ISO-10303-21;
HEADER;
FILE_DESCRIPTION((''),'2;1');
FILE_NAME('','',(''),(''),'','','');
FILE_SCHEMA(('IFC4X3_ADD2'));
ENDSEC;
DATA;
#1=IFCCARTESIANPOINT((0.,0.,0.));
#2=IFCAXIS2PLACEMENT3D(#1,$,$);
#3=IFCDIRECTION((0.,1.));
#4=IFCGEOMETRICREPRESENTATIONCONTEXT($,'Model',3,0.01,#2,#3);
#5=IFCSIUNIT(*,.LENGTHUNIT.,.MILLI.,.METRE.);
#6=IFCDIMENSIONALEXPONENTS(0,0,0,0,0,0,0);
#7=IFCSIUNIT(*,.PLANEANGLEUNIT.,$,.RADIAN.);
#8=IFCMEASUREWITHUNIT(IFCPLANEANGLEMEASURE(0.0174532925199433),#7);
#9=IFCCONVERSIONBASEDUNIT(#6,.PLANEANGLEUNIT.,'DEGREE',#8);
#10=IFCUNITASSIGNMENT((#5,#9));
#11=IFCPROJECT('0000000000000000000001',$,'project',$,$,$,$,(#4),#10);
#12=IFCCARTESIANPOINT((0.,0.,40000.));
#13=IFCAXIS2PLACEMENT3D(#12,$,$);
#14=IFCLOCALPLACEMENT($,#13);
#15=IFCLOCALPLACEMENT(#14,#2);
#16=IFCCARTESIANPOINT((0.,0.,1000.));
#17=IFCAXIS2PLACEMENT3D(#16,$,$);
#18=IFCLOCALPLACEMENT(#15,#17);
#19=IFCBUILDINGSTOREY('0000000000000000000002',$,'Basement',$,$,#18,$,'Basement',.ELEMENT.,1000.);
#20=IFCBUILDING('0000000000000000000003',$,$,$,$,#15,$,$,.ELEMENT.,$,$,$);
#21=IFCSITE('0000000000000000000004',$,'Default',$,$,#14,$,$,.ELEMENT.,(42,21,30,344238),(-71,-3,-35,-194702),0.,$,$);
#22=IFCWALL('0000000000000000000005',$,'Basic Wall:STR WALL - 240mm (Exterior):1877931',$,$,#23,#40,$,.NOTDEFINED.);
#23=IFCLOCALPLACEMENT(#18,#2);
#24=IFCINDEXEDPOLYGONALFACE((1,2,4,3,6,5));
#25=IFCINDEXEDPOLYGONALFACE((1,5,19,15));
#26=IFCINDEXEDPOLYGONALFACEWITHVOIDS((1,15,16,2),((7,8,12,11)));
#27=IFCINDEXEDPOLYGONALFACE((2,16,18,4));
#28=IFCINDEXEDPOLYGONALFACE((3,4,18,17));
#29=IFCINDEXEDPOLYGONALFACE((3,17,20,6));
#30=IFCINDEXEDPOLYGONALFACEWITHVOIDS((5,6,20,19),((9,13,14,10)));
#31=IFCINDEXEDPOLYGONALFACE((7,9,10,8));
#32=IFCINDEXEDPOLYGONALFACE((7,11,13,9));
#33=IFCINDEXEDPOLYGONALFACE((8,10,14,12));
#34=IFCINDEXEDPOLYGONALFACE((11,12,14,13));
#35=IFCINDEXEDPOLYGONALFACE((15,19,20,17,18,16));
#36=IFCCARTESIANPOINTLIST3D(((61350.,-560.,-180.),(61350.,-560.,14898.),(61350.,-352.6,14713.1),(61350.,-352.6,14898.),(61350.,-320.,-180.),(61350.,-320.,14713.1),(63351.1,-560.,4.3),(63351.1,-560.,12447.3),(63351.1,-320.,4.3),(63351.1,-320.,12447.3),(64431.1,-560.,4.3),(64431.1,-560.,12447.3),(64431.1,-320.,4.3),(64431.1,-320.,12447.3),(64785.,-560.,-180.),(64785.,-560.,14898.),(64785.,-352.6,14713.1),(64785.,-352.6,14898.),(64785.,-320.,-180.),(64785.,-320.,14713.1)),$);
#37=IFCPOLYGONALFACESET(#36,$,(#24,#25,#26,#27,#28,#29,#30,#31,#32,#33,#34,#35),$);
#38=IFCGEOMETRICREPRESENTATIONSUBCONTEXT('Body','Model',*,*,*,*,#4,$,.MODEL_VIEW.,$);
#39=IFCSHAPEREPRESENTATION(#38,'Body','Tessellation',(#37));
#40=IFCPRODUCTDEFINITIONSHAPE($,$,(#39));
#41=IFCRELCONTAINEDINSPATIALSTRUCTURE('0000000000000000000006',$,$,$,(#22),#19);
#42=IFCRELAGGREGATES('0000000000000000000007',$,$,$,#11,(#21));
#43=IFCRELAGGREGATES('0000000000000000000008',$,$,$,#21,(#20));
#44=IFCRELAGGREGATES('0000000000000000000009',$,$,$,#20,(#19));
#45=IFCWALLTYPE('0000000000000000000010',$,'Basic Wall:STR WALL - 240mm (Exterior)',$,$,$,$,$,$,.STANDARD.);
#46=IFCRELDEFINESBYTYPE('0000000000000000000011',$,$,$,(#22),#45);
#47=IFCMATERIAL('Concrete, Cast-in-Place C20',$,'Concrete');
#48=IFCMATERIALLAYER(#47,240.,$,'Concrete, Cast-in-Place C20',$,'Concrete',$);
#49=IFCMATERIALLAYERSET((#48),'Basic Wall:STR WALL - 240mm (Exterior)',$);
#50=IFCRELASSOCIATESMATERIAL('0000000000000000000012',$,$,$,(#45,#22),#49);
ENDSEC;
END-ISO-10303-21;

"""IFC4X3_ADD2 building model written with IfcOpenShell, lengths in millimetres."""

from ifc_helpers import new_model, entity, si_unit, converted_unit, direction, frame, frame_2d, origin, place, context, subcontext, project, spatial, polyline, rectangle, extrude, clip, bounded_halfspace, material, layer, layer_set, type_object, element, save


model = new_model("IFC4X3_ADD2")

# Units and contexts
model_context = context("Model", 3, precision=0.01, world=origin(), true_north=direction((0.0, 1.0)))
body_context = subcontext(model_context, "Body", "Model", "MODEL_VIEW")
ifc_project = project(units=[si_unit("LENGTHUNIT", "METRE", prefix="MILLI"), converted_unit("PLANEANGLEUNIT", "DEGREE", entity("IfcPlaneAngleMeasure", 0.0174532925199433), si_unit("PLANEANGLEUNIT", "RADIAN"), dimensions=[0, 0, 0, 0, 0, 0, 0])], contexts=[model_context])

# Site, building, storey
site_placement = place(None, frame((0.0, 0.0, 40000.0)))
site = spatial("IfcSite", under=ifc_project, at=site_placement, Name="Default", CompositionType="ELEMENT", RefLatitude=(42, 21, 30, 344238), RefLongitude=(-71, -3, -35, -194702), RefElevation=0.0)
building_placement = place(site_placement, origin())
building = spatial("IfcBuilding", under=site, at=building_placement, CompositionType="ELEMENT")
storey_placement = place(building_placement, frame((0.0, 0.0, 1000.0)))
storey = spatial("IfcBuildingStorey", under=building, at=storey_placement, Name="Basement", LongName="Basement", CompositionType="ELEMENT", Elevation=1000.0)

# Shared definitions
ifc_material_1 = material(Name="Concrete, Cast-in-Place C20", Category="Concrete")
ifc_layer = layer(ifc_material_1, 240.0, Name="Concrete, Cast-in-Place C20", Category="Concrete")
ifc_layer_set = layer_set([ifc_layer], Name="Basic Wall:STR WALL - 240mm (Exterior)")
wall_type = type_object("IfcWallType", Name="Basic Wall:STR WALL - 240mm (Exterior)", PredefinedType="STANDARD", material=ifc_layer_set)

# Wall, opening
wall_1_placement = place(storey_placement, frame((64785.0, -440.0, -180.0), z_axis=(0.0, 0.0, 1.0), x_axis=(-1.0, 0.0, 0.0)))
wall_1 = element("IfcWall", 1, at=wall_1_placement, inside=storey, type_object=wall_type, material=ifc_layer_set, Name="Basic Wall:STR WALL - 240mm (Exterior):1877931", PredefinedType="NOTDEFINED", context=body_context, shape_type="Clipping", body=[
    clip(clip(extrude(rectangle(XDim=3435.0, YDim=240.0, at=frame_2d((1717.5, 0.0), x_axis=(-1.0, 0.0))), origin(), (0.0, 0.0, 1.0), 15078.0), bounded_halfspace(frame((3435.0, -87.4, 15078.0), z_axis=(0.0, 0.0, -1.0), x_axis=(0.0, 1.0, 0.0)), True, frame((3435.0, -87.4, 15078.0)), polyline([(0.0, 0.0), (0.0, 207.4), (-3195.0, 207.4), (-3435.0, 207.4), (-3435.0, 0.0), (0.0, 0.0)]))), bounded_halfspace(frame((0.0, -120.0, 14893.1), z_axis=(0.0, 0.0, 1.0), x_axis=(0.0, 1.0, 0.0)), False, frame((0.0, -120.0, 14893.1)), polyline([(0.0, 0.0), (3435.0, 0.0), (3435.0, 32.6), (0.0, 32.6), (0.0, 0.0)]))),
])
opening_1_placement = place(wall_1_placement, frame((1433.9, 120.0, 184.3)))
element("IfcOpeningElement", 2, at=opening_1_placement, cuts=wall_1, PredefinedType="OPENING", context=body_context, shape_type="SweptSolid", body=[
    extrude(rectangle(XDim=12443.0, YDim=1080.0, at=frame_2d((0.0, 0.0), x_axis=(1.0, 0.0))), frame((-540.0, -240.0, 6221.5), z_axis=(0.0, 1.0, 0.0), x_axis=(0.0, 0.0, -1.0)), (0.0, 0.0, 1.0), 240.0),
])

save(model, "model.ifc")
